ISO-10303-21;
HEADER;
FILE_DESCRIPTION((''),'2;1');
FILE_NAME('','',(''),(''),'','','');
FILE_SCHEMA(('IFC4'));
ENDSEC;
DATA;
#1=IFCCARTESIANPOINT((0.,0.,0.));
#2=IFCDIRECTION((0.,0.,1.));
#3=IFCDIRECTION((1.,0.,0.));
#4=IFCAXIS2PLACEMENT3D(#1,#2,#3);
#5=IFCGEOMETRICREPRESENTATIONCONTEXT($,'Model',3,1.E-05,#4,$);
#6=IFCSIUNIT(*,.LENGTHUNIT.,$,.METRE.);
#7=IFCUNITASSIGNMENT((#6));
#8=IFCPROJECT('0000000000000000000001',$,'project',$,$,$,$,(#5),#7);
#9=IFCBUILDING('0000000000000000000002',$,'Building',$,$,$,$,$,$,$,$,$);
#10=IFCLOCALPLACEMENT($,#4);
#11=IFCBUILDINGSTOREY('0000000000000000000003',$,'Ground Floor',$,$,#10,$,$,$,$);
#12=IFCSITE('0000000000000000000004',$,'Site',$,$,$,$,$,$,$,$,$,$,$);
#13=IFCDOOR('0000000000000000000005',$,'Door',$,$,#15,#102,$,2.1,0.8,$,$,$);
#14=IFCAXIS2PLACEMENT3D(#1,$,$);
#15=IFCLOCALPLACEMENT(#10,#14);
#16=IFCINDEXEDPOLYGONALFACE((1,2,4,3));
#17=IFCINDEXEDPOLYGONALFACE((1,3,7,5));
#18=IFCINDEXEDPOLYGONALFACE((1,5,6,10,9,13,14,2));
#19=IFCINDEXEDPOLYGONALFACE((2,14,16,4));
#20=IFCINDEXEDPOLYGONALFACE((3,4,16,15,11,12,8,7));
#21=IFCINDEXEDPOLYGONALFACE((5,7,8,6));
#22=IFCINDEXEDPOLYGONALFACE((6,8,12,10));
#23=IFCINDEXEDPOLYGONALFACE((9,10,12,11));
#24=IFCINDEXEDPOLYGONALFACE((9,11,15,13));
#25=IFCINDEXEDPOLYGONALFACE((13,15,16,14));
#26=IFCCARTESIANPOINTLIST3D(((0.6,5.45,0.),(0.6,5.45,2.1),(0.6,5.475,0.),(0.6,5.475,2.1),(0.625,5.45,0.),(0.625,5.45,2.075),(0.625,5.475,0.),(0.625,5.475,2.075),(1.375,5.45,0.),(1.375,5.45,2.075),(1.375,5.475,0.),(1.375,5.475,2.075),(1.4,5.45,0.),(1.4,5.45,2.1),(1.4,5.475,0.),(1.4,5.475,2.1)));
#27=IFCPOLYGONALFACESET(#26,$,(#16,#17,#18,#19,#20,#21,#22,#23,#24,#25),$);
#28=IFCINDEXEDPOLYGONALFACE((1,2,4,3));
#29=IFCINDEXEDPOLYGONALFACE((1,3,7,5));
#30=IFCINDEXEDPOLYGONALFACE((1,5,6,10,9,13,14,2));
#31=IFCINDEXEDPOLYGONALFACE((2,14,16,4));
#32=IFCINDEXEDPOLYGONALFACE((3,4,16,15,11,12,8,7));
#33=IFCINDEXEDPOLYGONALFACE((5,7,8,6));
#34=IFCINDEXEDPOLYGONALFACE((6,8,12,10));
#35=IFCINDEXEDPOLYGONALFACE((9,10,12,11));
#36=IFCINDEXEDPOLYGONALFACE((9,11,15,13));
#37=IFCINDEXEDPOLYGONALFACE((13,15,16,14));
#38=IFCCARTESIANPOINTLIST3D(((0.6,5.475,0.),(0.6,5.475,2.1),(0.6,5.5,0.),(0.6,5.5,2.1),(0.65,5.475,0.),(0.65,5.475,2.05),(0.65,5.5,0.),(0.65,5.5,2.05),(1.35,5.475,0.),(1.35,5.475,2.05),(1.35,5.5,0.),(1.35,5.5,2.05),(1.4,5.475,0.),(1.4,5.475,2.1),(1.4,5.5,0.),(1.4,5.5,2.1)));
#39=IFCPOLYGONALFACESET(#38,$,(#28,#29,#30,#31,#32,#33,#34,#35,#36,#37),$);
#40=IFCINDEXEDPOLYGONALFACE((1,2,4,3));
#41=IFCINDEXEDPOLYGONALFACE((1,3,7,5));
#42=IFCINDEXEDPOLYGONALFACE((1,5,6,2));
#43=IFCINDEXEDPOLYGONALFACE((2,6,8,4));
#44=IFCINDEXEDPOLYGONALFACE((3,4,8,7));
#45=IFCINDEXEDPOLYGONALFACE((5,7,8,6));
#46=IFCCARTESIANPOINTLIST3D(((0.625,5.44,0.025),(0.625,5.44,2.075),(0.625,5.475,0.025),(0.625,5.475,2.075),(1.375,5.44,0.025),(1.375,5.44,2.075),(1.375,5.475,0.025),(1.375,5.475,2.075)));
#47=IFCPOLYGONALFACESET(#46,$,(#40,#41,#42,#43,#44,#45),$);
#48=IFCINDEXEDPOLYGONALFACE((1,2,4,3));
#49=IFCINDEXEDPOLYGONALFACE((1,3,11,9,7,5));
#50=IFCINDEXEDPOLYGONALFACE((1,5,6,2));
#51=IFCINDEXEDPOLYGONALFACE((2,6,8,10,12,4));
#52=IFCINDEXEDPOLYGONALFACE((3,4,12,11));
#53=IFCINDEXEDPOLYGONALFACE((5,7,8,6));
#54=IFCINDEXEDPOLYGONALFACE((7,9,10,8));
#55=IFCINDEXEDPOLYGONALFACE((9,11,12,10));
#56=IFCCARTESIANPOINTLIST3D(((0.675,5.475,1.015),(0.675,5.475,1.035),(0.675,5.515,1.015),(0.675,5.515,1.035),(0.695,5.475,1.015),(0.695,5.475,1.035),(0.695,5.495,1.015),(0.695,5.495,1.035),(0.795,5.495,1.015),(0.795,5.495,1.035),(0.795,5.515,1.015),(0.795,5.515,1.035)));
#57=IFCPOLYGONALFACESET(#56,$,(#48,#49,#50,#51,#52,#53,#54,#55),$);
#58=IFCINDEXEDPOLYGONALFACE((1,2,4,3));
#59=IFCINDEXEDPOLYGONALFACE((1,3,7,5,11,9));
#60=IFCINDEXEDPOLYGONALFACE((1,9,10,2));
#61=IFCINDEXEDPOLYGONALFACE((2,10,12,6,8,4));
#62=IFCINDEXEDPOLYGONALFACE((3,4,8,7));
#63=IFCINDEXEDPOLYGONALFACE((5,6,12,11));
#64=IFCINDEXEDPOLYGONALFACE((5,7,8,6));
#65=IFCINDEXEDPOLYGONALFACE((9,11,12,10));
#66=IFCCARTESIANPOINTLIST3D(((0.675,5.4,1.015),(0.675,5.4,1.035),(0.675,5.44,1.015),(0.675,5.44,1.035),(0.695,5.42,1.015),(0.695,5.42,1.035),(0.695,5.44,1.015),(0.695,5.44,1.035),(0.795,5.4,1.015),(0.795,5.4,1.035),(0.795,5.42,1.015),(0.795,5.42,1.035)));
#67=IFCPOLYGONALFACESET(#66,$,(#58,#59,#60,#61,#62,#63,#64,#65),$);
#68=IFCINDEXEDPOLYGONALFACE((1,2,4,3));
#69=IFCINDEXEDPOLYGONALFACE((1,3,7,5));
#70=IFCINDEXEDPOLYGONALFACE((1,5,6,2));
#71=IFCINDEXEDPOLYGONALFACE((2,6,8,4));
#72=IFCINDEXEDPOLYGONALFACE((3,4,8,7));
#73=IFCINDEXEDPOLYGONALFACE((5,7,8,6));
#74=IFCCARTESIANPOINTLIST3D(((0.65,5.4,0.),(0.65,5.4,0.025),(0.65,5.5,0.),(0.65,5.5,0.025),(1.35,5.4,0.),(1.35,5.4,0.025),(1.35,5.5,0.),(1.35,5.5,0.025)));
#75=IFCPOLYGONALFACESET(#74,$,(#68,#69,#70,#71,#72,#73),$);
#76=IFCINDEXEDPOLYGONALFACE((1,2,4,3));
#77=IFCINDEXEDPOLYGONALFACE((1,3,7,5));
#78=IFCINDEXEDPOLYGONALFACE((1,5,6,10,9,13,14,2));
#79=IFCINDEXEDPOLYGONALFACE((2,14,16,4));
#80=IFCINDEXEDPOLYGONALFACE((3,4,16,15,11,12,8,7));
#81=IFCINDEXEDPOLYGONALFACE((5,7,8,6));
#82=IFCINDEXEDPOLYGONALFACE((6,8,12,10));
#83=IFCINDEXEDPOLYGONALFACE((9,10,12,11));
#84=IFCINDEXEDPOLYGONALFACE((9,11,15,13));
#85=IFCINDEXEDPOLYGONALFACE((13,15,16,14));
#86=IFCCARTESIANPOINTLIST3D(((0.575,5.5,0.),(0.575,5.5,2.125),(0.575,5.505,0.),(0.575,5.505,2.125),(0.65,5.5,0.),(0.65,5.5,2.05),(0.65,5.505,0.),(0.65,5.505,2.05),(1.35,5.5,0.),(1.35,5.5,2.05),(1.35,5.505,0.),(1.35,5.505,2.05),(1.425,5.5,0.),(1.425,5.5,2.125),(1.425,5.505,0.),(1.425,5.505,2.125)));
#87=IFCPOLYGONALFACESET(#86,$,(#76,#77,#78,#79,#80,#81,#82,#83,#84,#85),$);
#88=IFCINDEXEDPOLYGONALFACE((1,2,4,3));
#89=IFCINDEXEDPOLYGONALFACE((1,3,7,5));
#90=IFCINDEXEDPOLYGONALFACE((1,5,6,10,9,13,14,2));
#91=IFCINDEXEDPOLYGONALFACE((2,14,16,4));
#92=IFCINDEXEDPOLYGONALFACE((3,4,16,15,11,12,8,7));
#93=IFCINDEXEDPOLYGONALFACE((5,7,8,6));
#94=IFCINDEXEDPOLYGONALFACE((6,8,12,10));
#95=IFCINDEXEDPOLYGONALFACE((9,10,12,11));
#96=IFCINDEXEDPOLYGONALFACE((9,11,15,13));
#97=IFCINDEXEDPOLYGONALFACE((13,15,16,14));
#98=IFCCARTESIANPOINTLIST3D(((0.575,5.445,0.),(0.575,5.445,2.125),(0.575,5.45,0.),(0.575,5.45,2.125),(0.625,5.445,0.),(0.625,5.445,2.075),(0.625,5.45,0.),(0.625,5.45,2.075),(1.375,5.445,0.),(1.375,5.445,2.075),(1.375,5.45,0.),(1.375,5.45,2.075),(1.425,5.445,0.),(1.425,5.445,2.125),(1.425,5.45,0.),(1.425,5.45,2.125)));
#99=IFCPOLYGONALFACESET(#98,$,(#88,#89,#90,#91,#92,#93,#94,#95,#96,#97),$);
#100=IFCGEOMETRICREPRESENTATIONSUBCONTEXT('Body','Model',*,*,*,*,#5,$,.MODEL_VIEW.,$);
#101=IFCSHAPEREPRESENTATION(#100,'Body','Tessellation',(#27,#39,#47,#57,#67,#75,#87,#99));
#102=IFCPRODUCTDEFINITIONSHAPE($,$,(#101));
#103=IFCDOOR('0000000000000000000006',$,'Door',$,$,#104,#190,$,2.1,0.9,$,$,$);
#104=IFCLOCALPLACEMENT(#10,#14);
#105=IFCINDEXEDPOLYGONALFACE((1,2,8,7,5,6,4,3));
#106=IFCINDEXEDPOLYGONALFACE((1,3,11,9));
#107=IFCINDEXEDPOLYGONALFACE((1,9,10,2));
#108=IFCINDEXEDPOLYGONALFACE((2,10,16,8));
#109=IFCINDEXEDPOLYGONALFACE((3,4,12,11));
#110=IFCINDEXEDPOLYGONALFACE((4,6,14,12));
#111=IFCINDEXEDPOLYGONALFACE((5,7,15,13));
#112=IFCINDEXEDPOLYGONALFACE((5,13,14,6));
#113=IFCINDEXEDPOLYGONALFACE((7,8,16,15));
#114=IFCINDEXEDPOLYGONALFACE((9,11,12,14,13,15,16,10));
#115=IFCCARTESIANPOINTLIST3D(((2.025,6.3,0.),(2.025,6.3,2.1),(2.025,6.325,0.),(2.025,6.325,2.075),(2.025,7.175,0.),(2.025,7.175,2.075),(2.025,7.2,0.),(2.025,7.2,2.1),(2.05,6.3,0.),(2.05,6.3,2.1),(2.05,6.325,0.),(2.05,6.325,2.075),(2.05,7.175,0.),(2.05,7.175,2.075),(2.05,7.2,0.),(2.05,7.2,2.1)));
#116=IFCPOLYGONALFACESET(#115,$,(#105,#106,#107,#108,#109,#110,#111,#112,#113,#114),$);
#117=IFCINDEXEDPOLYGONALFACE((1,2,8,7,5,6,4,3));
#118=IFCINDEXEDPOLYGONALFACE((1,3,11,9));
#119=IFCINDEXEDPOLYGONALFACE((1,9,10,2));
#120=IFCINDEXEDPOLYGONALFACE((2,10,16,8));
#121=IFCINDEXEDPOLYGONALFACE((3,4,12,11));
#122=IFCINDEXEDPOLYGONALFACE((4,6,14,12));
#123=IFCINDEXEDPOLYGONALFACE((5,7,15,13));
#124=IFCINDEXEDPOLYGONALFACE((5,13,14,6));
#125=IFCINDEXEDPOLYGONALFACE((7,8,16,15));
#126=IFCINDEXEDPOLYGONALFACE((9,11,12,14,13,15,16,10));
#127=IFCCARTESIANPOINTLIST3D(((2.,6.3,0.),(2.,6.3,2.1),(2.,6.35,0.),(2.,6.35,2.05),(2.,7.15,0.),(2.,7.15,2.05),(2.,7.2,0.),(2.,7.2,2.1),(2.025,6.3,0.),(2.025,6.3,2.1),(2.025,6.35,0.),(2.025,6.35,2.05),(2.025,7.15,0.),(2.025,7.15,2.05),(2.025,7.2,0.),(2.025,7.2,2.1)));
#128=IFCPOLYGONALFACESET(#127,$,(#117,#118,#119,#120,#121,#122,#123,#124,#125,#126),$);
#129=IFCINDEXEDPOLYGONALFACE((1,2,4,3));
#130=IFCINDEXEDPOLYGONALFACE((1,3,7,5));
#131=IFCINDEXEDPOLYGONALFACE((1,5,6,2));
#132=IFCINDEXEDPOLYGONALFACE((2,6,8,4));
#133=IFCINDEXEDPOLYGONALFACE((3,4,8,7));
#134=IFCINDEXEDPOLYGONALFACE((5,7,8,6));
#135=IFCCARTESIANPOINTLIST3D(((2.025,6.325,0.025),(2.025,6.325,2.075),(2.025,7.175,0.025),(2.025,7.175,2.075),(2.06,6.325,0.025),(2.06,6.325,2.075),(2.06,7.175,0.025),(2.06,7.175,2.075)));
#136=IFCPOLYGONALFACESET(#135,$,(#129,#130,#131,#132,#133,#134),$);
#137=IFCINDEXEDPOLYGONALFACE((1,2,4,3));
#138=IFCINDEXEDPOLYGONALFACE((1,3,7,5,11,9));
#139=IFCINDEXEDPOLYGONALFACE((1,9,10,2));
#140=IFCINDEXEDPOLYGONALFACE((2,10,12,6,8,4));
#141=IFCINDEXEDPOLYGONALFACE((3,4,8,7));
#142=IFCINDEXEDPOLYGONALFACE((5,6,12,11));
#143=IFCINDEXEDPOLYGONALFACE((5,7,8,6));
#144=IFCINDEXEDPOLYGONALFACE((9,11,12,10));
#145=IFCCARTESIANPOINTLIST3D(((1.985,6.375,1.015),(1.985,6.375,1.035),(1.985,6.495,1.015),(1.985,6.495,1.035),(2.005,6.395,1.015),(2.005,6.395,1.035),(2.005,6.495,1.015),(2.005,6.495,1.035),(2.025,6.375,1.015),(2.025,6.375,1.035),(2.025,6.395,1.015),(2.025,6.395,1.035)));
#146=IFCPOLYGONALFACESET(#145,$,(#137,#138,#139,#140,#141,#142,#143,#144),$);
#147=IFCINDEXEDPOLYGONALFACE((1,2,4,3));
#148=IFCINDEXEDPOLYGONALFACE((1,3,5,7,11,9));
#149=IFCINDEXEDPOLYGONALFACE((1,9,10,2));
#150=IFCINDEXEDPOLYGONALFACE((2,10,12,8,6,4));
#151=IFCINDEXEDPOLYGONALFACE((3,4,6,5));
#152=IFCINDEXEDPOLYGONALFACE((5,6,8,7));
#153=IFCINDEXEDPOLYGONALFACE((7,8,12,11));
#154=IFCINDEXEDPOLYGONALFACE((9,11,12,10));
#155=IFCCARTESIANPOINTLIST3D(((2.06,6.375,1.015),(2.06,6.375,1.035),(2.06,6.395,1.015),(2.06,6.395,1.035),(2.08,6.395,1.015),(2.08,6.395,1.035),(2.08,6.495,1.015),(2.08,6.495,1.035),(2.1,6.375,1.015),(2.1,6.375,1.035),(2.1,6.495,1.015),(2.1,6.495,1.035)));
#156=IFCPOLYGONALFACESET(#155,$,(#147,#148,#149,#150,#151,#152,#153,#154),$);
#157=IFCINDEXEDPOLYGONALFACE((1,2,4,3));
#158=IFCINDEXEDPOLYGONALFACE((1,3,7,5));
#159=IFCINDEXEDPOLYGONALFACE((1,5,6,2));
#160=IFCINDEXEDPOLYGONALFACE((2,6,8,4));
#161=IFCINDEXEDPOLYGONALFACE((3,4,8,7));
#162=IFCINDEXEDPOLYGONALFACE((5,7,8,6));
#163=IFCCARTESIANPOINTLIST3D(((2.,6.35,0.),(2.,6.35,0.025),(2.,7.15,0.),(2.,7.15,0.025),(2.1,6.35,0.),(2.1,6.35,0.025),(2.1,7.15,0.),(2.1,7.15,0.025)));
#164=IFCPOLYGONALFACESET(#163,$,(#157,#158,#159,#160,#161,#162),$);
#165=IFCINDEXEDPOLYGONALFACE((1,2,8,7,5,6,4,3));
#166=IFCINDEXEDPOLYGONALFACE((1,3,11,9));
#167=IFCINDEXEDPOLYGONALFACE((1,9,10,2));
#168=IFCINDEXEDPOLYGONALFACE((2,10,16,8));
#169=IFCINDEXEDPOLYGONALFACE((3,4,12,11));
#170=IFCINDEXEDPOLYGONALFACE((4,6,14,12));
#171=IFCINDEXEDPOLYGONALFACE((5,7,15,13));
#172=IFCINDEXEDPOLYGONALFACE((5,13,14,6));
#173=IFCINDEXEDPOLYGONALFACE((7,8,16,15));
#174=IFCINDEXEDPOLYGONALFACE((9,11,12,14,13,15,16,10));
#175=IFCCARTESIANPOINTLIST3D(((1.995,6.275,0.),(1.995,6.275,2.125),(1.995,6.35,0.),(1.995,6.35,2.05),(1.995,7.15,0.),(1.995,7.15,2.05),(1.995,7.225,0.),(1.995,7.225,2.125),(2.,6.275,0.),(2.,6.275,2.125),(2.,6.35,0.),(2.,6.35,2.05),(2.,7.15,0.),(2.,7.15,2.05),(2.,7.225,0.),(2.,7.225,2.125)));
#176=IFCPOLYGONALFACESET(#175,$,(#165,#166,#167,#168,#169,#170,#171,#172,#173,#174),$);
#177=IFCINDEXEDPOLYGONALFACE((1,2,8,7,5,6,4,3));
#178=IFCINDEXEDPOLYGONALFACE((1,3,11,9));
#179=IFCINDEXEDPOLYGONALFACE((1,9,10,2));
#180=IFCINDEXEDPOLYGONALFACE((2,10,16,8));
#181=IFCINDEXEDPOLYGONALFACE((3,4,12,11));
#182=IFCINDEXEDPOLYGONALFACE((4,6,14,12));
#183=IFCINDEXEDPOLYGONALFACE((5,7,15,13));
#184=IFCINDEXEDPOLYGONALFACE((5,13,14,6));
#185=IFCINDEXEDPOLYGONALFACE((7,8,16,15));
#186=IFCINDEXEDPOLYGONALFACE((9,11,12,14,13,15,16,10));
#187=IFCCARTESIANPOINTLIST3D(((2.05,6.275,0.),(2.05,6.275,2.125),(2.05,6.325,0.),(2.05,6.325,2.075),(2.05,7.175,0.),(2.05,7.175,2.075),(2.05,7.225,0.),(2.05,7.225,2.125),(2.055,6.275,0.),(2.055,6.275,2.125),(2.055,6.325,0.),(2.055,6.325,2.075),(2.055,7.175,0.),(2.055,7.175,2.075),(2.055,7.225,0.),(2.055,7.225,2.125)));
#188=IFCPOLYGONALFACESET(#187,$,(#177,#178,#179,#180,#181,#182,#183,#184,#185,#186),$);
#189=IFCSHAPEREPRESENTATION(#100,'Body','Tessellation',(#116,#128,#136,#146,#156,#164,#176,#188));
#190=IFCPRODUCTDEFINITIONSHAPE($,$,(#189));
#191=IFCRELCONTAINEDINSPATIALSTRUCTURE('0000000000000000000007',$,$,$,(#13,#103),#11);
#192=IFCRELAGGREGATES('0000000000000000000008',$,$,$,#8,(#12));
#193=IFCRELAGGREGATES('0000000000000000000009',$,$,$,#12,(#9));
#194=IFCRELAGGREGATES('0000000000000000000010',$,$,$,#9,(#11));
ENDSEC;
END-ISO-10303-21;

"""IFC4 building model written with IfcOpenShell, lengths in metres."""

from ifc_helpers import new_model, si_unit, frame, origin_with_axes, place, context, subcontext, project, spatial, line, indexed_curve, outline, extrude, element, save


model = new_model("IFC4")

# Units and contexts
model_context = context("Model", 3, precision=1e-05, world=origin_with_axes())
body_context = subcontext(model_context, "Body", "Model", "MODEL_VIEW")
ifc_project = project(units=[si_unit("LENGTHUNIT", "METRE")], contexts=[model_context])

# Site, building, storey
site = spatial("IfcSite", under=ifc_project, Name="Site")
building = spatial("IfcBuilding", under=site, Name="Building")
storey_placement = place(None, origin_with_axes())
storey = spatial("IfcBuildingStorey", under=building, at=storey_placement, Name="Ground Floor")

# Doors
door_1_placement = place(storey_placement, frame((1.4, 5.5, 0.0), z_axis=(0.0, 0.0, 1.0), x_axis=(-1.0, 0.0, 0.0)))
element("IfcDoor", 1, at=door_1_placement, inside=storey, Name="Door", OverallHeight=2.1, OverallWidth=0.8, context=body_context, shape_type="SweptSolid", body=[
    extrude(outline(indexed_curve([(0.0, 0.0), (0.0, 2.1), (0.8, 2.1), (0.8, 0.0), (0.775, 0.0), (0.775, 2.075), (0.025, 2.075), (0.025, 0.0)], segments=[line(1, 2, 3, 4, 5, 6, 7, 8, 1)])), frame((0.0, 0.025, 0.0), z_axis=(0.0, -1.0, 0.0), x_axis=(1.0, 0.0, 0.0)), (0.0, 0.0, -1.0), 0.025),
    extrude(outline(indexed_curve([(0.0, 0.0), (0.0, 2.1), (0.8, 2.1), (0.8, 0.0), (0.75, 0.0), (0.75, 2.05), (0.05, 2.05), (0.05, 0.0)], segments=[line(1, 2, 3, 4, 5, 6, 7, 8, 1)])), frame((0.0, 0.0, 0.0), z_axis=(0.0, -1.0, 0.0), x_axis=(1.0, 0.0, 0.0)), (0.0, 0.0, -1.0), 0.025),
    extrude(outline(indexed_curve([(0.0, 0.0), (0.75, 0.0), (0.75, 0.035), (0.0, 0.035)], segments=[line(1, 2, 3, 4, 1)])), frame((0.025, 0.025, 0.025), z_axis=(0.0, 0.0, 1.0), x_axis=(1.0, 0.0, 0.0)), (0.0, 0.0, 1.0), 2.05),
    extrude(outline(indexed_curve([(0.0, 0.0), (0.0, -0.04), (-0.12, -0.04), (-0.12, -0.02), (-0.02, -0.02), (-0.02, 0.0)], segments=[line(1, 2, 3, 4, 5, 6, 1)])), frame((0.725, 0.025, 1.015), z_axis=(0.0, 0.0, 1.0), x_axis=(1.0, 0.0, 0.0)), (0.0, 0.0, 1.0), 0.02),
    extrude(outline(indexed_curve([(0.0, 0.0), (0.0, 0.04), (-0.12, 0.04), (-0.12, 0.02), (-0.02, 0.02), (-0.02, 0.0)], segments=[line(1, 2, 3, 4, 5, 6, 1)])), frame((0.725, 0.06, 1.015), z_axis=(0.0, 0.0, 1.0), x_axis=(1.0, 0.0, 0.0)), (0.0, 0.0, 1.0), 0.02),
    extrude(outline(indexed_curve([(0.0, 0.0), (0.7, 0.0), (0.7, 0.1), (0.0, 0.1)], segments=[line(1, 2, 3, 4, 1)])), frame((0.05, 0.0, 0.0), z_axis=(0.0, 0.0, 1.0), x_axis=(1.0, 0.0, 0.0)), (0.0, 0.0, 1.0), 0.025),
    extrude(outline(indexed_curve([(0.0, 0.0), (0.0, 2.125), (0.85, 2.125), (0.85, 0.0), (0.775, 0.0), (0.775, 2.05), (0.075, 2.05), (0.075, 0.0)], segments=[line(1, 2, 3, 4, 5, 6, 7, 8, 1)])), frame((-0.025, -0.005, 0.0), z_axis=(0.0, -1.0, 0.0), x_axis=(1.0, 0.0, 0.0)), (0.0, 0.0, -1.0), 0.005),
    extrude(outline(indexed_curve([(0.0, 0.0), (0.0, 2.125), (0.85, 2.125), (0.85, 0.0), (0.8, 0.0), (0.8, 2.075), (0.05, 2.075), (0.05, 0.0)], segments=[line(1, 2, 3, 4, 5, 6, 7, 8, 1)])), frame((-0.025, 0.05, 0.0), z_axis=(0.0, -1.0, 0.0), x_axis=(1.0, 0.0, 0.0)), (0.0, 0.0, -1.0), 0.005),
])
door_2_placement = place(storey_placement, frame((2.0, 7.2, 0.0), z_axis=(0.0, 0.0, 1.0), x_axis=(0.0, -1.0, 0.0)))
element("IfcDoor", 2, at=door_2_placement, inside=storey, Name="Door", OverallHeight=2.1, OverallWidth=0.9, context=body_context, shape_type="SweptSolid", body=[
    extrude(outline(indexed_curve([(0.0, 0.0), (0.0, 2.1), (0.9, 2.1), (0.9, 0.0), (0.875, 0.0), (0.875, 2.075), (0.025, 2.075), (0.025, 0.0)], segments=[line(1, 2, 3, 4, 5, 6, 7, 8, 1)])), frame((0.0, 0.025, 0.0), z_axis=(0.0, -1.0, 0.0), x_axis=(1.0, 0.0, 0.0)), (0.0, 0.0, -1.0), 0.025),
    extrude(outline(indexed_curve([(0.0, 0.0), (0.0, 2.1), (0.9, 2.1), (0.9, 0.0), (0.85, 0.0), (0.85, 2.05), (0.05, 2.05), (0.05, 0.0)], segments=[line(1, 2, 3, 4, 5, 6, 7, 8, 1)])), frame((0.0, 0.0, 0.0), z_axis=(0.0, -1.0, 0.0), x_axis=(1.0, 0.0, 0.0)), (0.0, 0.0, -1.0), 0.025),
    extrude(outline(indexed_curve([(0.0, 0.0), (0.85, 0.0), (0.85, 0.035), (0.0, 0.035)], segments=[line(1, 2, 3, 4, 1)])), frame((0.025, 0.025, 0.025), z_axis=(0.0, 0.0, 1.0), x_axis=(1.0, 0.0, 0.0)), (0.0, 0.0, 1.0), 2.05),
    extrude(outline(indexed_curve([(0.0, 0.0), (0.0, -0.04), (-0.12, -0.04), (-0.12, -0.02), (-0.02, -0.02), (-0.02, 0.0)], segments=[line(1, 2, 3, 4, 5, 6, 1)])), frame((0.825, 0.025, 1.015), z_axis=(0.0, 0.0, 1.0), x_axis=(1.0, 0.0, 0.0)), (0.0, 0.0, 1.0), 0.02),
    extrude(outline(indexed_curve([(0.0, 0.0), (0.0, 0.04), (-0.12, 0.04), (-0.12, 0.02), (-0.02, 0.02), (-0.02, 0.0)], segments=[line(1, 2, 3, 4, 5, 6, 1)])), frame((0.825, 0.06, 1.015), z_axis=(0.0, 0.0, 1.0), x_axis=(1.0, 0.0, 0.0)), (0.0, 0.0, 1.0), 0.02),
    extrude(outline(indexed_curve([(0.0, 0.0), (0.8, 0.0), (0.8, 0.1), (0.0, 0.1)], segments=[line(1, 2, 3, 4, 1)])), frame((0.05, 0.0, 0.0), z_axis=(0.0, 0.0, 1.0), x_axis=(1.0, 0.0, 0.0)), (0.0, 0.0, 1.0), 0.025),
    extrude(outline(indexed_curve([(0.0, 0.0), (0.0, 2.125), (0.95, 2.125), (0.95, 0.0), (0.875, 0.0), (0.875, 2.05), (0.075, 2.05), (0.075, 0.0)], segments=[line(1, 2, 3, 4, 5, 6, 7, 8, 1)])), frame((-0.025, -0.005, 0.0), z_axis=(0.0, -1.0, 0.0), x_axis=(1.0, 0.0, 0.0)), (0.0, 0.0, -1.0), 0.005),
    extrude(outline(indexed_curve([(0.0, 0.0), (0.0, 2.125), (0.95, 2.125), (0.95, 0.0), (0.9, 0.0), (0.9, 2.075), (0.05, 2.075), (0.05, 0.0)], segments=[line(1, 2, 3, 4, 5, 6, 7, 8, 1)])), frame((-0.025, 0.05, 0.0), z_axis=(0.0, -1.0, 0.0), x_axis=(1.0, 0.0, 0.0)), (0.0, 0.0, -1.0), 0.005),
])

save(model, "model.ifc")
